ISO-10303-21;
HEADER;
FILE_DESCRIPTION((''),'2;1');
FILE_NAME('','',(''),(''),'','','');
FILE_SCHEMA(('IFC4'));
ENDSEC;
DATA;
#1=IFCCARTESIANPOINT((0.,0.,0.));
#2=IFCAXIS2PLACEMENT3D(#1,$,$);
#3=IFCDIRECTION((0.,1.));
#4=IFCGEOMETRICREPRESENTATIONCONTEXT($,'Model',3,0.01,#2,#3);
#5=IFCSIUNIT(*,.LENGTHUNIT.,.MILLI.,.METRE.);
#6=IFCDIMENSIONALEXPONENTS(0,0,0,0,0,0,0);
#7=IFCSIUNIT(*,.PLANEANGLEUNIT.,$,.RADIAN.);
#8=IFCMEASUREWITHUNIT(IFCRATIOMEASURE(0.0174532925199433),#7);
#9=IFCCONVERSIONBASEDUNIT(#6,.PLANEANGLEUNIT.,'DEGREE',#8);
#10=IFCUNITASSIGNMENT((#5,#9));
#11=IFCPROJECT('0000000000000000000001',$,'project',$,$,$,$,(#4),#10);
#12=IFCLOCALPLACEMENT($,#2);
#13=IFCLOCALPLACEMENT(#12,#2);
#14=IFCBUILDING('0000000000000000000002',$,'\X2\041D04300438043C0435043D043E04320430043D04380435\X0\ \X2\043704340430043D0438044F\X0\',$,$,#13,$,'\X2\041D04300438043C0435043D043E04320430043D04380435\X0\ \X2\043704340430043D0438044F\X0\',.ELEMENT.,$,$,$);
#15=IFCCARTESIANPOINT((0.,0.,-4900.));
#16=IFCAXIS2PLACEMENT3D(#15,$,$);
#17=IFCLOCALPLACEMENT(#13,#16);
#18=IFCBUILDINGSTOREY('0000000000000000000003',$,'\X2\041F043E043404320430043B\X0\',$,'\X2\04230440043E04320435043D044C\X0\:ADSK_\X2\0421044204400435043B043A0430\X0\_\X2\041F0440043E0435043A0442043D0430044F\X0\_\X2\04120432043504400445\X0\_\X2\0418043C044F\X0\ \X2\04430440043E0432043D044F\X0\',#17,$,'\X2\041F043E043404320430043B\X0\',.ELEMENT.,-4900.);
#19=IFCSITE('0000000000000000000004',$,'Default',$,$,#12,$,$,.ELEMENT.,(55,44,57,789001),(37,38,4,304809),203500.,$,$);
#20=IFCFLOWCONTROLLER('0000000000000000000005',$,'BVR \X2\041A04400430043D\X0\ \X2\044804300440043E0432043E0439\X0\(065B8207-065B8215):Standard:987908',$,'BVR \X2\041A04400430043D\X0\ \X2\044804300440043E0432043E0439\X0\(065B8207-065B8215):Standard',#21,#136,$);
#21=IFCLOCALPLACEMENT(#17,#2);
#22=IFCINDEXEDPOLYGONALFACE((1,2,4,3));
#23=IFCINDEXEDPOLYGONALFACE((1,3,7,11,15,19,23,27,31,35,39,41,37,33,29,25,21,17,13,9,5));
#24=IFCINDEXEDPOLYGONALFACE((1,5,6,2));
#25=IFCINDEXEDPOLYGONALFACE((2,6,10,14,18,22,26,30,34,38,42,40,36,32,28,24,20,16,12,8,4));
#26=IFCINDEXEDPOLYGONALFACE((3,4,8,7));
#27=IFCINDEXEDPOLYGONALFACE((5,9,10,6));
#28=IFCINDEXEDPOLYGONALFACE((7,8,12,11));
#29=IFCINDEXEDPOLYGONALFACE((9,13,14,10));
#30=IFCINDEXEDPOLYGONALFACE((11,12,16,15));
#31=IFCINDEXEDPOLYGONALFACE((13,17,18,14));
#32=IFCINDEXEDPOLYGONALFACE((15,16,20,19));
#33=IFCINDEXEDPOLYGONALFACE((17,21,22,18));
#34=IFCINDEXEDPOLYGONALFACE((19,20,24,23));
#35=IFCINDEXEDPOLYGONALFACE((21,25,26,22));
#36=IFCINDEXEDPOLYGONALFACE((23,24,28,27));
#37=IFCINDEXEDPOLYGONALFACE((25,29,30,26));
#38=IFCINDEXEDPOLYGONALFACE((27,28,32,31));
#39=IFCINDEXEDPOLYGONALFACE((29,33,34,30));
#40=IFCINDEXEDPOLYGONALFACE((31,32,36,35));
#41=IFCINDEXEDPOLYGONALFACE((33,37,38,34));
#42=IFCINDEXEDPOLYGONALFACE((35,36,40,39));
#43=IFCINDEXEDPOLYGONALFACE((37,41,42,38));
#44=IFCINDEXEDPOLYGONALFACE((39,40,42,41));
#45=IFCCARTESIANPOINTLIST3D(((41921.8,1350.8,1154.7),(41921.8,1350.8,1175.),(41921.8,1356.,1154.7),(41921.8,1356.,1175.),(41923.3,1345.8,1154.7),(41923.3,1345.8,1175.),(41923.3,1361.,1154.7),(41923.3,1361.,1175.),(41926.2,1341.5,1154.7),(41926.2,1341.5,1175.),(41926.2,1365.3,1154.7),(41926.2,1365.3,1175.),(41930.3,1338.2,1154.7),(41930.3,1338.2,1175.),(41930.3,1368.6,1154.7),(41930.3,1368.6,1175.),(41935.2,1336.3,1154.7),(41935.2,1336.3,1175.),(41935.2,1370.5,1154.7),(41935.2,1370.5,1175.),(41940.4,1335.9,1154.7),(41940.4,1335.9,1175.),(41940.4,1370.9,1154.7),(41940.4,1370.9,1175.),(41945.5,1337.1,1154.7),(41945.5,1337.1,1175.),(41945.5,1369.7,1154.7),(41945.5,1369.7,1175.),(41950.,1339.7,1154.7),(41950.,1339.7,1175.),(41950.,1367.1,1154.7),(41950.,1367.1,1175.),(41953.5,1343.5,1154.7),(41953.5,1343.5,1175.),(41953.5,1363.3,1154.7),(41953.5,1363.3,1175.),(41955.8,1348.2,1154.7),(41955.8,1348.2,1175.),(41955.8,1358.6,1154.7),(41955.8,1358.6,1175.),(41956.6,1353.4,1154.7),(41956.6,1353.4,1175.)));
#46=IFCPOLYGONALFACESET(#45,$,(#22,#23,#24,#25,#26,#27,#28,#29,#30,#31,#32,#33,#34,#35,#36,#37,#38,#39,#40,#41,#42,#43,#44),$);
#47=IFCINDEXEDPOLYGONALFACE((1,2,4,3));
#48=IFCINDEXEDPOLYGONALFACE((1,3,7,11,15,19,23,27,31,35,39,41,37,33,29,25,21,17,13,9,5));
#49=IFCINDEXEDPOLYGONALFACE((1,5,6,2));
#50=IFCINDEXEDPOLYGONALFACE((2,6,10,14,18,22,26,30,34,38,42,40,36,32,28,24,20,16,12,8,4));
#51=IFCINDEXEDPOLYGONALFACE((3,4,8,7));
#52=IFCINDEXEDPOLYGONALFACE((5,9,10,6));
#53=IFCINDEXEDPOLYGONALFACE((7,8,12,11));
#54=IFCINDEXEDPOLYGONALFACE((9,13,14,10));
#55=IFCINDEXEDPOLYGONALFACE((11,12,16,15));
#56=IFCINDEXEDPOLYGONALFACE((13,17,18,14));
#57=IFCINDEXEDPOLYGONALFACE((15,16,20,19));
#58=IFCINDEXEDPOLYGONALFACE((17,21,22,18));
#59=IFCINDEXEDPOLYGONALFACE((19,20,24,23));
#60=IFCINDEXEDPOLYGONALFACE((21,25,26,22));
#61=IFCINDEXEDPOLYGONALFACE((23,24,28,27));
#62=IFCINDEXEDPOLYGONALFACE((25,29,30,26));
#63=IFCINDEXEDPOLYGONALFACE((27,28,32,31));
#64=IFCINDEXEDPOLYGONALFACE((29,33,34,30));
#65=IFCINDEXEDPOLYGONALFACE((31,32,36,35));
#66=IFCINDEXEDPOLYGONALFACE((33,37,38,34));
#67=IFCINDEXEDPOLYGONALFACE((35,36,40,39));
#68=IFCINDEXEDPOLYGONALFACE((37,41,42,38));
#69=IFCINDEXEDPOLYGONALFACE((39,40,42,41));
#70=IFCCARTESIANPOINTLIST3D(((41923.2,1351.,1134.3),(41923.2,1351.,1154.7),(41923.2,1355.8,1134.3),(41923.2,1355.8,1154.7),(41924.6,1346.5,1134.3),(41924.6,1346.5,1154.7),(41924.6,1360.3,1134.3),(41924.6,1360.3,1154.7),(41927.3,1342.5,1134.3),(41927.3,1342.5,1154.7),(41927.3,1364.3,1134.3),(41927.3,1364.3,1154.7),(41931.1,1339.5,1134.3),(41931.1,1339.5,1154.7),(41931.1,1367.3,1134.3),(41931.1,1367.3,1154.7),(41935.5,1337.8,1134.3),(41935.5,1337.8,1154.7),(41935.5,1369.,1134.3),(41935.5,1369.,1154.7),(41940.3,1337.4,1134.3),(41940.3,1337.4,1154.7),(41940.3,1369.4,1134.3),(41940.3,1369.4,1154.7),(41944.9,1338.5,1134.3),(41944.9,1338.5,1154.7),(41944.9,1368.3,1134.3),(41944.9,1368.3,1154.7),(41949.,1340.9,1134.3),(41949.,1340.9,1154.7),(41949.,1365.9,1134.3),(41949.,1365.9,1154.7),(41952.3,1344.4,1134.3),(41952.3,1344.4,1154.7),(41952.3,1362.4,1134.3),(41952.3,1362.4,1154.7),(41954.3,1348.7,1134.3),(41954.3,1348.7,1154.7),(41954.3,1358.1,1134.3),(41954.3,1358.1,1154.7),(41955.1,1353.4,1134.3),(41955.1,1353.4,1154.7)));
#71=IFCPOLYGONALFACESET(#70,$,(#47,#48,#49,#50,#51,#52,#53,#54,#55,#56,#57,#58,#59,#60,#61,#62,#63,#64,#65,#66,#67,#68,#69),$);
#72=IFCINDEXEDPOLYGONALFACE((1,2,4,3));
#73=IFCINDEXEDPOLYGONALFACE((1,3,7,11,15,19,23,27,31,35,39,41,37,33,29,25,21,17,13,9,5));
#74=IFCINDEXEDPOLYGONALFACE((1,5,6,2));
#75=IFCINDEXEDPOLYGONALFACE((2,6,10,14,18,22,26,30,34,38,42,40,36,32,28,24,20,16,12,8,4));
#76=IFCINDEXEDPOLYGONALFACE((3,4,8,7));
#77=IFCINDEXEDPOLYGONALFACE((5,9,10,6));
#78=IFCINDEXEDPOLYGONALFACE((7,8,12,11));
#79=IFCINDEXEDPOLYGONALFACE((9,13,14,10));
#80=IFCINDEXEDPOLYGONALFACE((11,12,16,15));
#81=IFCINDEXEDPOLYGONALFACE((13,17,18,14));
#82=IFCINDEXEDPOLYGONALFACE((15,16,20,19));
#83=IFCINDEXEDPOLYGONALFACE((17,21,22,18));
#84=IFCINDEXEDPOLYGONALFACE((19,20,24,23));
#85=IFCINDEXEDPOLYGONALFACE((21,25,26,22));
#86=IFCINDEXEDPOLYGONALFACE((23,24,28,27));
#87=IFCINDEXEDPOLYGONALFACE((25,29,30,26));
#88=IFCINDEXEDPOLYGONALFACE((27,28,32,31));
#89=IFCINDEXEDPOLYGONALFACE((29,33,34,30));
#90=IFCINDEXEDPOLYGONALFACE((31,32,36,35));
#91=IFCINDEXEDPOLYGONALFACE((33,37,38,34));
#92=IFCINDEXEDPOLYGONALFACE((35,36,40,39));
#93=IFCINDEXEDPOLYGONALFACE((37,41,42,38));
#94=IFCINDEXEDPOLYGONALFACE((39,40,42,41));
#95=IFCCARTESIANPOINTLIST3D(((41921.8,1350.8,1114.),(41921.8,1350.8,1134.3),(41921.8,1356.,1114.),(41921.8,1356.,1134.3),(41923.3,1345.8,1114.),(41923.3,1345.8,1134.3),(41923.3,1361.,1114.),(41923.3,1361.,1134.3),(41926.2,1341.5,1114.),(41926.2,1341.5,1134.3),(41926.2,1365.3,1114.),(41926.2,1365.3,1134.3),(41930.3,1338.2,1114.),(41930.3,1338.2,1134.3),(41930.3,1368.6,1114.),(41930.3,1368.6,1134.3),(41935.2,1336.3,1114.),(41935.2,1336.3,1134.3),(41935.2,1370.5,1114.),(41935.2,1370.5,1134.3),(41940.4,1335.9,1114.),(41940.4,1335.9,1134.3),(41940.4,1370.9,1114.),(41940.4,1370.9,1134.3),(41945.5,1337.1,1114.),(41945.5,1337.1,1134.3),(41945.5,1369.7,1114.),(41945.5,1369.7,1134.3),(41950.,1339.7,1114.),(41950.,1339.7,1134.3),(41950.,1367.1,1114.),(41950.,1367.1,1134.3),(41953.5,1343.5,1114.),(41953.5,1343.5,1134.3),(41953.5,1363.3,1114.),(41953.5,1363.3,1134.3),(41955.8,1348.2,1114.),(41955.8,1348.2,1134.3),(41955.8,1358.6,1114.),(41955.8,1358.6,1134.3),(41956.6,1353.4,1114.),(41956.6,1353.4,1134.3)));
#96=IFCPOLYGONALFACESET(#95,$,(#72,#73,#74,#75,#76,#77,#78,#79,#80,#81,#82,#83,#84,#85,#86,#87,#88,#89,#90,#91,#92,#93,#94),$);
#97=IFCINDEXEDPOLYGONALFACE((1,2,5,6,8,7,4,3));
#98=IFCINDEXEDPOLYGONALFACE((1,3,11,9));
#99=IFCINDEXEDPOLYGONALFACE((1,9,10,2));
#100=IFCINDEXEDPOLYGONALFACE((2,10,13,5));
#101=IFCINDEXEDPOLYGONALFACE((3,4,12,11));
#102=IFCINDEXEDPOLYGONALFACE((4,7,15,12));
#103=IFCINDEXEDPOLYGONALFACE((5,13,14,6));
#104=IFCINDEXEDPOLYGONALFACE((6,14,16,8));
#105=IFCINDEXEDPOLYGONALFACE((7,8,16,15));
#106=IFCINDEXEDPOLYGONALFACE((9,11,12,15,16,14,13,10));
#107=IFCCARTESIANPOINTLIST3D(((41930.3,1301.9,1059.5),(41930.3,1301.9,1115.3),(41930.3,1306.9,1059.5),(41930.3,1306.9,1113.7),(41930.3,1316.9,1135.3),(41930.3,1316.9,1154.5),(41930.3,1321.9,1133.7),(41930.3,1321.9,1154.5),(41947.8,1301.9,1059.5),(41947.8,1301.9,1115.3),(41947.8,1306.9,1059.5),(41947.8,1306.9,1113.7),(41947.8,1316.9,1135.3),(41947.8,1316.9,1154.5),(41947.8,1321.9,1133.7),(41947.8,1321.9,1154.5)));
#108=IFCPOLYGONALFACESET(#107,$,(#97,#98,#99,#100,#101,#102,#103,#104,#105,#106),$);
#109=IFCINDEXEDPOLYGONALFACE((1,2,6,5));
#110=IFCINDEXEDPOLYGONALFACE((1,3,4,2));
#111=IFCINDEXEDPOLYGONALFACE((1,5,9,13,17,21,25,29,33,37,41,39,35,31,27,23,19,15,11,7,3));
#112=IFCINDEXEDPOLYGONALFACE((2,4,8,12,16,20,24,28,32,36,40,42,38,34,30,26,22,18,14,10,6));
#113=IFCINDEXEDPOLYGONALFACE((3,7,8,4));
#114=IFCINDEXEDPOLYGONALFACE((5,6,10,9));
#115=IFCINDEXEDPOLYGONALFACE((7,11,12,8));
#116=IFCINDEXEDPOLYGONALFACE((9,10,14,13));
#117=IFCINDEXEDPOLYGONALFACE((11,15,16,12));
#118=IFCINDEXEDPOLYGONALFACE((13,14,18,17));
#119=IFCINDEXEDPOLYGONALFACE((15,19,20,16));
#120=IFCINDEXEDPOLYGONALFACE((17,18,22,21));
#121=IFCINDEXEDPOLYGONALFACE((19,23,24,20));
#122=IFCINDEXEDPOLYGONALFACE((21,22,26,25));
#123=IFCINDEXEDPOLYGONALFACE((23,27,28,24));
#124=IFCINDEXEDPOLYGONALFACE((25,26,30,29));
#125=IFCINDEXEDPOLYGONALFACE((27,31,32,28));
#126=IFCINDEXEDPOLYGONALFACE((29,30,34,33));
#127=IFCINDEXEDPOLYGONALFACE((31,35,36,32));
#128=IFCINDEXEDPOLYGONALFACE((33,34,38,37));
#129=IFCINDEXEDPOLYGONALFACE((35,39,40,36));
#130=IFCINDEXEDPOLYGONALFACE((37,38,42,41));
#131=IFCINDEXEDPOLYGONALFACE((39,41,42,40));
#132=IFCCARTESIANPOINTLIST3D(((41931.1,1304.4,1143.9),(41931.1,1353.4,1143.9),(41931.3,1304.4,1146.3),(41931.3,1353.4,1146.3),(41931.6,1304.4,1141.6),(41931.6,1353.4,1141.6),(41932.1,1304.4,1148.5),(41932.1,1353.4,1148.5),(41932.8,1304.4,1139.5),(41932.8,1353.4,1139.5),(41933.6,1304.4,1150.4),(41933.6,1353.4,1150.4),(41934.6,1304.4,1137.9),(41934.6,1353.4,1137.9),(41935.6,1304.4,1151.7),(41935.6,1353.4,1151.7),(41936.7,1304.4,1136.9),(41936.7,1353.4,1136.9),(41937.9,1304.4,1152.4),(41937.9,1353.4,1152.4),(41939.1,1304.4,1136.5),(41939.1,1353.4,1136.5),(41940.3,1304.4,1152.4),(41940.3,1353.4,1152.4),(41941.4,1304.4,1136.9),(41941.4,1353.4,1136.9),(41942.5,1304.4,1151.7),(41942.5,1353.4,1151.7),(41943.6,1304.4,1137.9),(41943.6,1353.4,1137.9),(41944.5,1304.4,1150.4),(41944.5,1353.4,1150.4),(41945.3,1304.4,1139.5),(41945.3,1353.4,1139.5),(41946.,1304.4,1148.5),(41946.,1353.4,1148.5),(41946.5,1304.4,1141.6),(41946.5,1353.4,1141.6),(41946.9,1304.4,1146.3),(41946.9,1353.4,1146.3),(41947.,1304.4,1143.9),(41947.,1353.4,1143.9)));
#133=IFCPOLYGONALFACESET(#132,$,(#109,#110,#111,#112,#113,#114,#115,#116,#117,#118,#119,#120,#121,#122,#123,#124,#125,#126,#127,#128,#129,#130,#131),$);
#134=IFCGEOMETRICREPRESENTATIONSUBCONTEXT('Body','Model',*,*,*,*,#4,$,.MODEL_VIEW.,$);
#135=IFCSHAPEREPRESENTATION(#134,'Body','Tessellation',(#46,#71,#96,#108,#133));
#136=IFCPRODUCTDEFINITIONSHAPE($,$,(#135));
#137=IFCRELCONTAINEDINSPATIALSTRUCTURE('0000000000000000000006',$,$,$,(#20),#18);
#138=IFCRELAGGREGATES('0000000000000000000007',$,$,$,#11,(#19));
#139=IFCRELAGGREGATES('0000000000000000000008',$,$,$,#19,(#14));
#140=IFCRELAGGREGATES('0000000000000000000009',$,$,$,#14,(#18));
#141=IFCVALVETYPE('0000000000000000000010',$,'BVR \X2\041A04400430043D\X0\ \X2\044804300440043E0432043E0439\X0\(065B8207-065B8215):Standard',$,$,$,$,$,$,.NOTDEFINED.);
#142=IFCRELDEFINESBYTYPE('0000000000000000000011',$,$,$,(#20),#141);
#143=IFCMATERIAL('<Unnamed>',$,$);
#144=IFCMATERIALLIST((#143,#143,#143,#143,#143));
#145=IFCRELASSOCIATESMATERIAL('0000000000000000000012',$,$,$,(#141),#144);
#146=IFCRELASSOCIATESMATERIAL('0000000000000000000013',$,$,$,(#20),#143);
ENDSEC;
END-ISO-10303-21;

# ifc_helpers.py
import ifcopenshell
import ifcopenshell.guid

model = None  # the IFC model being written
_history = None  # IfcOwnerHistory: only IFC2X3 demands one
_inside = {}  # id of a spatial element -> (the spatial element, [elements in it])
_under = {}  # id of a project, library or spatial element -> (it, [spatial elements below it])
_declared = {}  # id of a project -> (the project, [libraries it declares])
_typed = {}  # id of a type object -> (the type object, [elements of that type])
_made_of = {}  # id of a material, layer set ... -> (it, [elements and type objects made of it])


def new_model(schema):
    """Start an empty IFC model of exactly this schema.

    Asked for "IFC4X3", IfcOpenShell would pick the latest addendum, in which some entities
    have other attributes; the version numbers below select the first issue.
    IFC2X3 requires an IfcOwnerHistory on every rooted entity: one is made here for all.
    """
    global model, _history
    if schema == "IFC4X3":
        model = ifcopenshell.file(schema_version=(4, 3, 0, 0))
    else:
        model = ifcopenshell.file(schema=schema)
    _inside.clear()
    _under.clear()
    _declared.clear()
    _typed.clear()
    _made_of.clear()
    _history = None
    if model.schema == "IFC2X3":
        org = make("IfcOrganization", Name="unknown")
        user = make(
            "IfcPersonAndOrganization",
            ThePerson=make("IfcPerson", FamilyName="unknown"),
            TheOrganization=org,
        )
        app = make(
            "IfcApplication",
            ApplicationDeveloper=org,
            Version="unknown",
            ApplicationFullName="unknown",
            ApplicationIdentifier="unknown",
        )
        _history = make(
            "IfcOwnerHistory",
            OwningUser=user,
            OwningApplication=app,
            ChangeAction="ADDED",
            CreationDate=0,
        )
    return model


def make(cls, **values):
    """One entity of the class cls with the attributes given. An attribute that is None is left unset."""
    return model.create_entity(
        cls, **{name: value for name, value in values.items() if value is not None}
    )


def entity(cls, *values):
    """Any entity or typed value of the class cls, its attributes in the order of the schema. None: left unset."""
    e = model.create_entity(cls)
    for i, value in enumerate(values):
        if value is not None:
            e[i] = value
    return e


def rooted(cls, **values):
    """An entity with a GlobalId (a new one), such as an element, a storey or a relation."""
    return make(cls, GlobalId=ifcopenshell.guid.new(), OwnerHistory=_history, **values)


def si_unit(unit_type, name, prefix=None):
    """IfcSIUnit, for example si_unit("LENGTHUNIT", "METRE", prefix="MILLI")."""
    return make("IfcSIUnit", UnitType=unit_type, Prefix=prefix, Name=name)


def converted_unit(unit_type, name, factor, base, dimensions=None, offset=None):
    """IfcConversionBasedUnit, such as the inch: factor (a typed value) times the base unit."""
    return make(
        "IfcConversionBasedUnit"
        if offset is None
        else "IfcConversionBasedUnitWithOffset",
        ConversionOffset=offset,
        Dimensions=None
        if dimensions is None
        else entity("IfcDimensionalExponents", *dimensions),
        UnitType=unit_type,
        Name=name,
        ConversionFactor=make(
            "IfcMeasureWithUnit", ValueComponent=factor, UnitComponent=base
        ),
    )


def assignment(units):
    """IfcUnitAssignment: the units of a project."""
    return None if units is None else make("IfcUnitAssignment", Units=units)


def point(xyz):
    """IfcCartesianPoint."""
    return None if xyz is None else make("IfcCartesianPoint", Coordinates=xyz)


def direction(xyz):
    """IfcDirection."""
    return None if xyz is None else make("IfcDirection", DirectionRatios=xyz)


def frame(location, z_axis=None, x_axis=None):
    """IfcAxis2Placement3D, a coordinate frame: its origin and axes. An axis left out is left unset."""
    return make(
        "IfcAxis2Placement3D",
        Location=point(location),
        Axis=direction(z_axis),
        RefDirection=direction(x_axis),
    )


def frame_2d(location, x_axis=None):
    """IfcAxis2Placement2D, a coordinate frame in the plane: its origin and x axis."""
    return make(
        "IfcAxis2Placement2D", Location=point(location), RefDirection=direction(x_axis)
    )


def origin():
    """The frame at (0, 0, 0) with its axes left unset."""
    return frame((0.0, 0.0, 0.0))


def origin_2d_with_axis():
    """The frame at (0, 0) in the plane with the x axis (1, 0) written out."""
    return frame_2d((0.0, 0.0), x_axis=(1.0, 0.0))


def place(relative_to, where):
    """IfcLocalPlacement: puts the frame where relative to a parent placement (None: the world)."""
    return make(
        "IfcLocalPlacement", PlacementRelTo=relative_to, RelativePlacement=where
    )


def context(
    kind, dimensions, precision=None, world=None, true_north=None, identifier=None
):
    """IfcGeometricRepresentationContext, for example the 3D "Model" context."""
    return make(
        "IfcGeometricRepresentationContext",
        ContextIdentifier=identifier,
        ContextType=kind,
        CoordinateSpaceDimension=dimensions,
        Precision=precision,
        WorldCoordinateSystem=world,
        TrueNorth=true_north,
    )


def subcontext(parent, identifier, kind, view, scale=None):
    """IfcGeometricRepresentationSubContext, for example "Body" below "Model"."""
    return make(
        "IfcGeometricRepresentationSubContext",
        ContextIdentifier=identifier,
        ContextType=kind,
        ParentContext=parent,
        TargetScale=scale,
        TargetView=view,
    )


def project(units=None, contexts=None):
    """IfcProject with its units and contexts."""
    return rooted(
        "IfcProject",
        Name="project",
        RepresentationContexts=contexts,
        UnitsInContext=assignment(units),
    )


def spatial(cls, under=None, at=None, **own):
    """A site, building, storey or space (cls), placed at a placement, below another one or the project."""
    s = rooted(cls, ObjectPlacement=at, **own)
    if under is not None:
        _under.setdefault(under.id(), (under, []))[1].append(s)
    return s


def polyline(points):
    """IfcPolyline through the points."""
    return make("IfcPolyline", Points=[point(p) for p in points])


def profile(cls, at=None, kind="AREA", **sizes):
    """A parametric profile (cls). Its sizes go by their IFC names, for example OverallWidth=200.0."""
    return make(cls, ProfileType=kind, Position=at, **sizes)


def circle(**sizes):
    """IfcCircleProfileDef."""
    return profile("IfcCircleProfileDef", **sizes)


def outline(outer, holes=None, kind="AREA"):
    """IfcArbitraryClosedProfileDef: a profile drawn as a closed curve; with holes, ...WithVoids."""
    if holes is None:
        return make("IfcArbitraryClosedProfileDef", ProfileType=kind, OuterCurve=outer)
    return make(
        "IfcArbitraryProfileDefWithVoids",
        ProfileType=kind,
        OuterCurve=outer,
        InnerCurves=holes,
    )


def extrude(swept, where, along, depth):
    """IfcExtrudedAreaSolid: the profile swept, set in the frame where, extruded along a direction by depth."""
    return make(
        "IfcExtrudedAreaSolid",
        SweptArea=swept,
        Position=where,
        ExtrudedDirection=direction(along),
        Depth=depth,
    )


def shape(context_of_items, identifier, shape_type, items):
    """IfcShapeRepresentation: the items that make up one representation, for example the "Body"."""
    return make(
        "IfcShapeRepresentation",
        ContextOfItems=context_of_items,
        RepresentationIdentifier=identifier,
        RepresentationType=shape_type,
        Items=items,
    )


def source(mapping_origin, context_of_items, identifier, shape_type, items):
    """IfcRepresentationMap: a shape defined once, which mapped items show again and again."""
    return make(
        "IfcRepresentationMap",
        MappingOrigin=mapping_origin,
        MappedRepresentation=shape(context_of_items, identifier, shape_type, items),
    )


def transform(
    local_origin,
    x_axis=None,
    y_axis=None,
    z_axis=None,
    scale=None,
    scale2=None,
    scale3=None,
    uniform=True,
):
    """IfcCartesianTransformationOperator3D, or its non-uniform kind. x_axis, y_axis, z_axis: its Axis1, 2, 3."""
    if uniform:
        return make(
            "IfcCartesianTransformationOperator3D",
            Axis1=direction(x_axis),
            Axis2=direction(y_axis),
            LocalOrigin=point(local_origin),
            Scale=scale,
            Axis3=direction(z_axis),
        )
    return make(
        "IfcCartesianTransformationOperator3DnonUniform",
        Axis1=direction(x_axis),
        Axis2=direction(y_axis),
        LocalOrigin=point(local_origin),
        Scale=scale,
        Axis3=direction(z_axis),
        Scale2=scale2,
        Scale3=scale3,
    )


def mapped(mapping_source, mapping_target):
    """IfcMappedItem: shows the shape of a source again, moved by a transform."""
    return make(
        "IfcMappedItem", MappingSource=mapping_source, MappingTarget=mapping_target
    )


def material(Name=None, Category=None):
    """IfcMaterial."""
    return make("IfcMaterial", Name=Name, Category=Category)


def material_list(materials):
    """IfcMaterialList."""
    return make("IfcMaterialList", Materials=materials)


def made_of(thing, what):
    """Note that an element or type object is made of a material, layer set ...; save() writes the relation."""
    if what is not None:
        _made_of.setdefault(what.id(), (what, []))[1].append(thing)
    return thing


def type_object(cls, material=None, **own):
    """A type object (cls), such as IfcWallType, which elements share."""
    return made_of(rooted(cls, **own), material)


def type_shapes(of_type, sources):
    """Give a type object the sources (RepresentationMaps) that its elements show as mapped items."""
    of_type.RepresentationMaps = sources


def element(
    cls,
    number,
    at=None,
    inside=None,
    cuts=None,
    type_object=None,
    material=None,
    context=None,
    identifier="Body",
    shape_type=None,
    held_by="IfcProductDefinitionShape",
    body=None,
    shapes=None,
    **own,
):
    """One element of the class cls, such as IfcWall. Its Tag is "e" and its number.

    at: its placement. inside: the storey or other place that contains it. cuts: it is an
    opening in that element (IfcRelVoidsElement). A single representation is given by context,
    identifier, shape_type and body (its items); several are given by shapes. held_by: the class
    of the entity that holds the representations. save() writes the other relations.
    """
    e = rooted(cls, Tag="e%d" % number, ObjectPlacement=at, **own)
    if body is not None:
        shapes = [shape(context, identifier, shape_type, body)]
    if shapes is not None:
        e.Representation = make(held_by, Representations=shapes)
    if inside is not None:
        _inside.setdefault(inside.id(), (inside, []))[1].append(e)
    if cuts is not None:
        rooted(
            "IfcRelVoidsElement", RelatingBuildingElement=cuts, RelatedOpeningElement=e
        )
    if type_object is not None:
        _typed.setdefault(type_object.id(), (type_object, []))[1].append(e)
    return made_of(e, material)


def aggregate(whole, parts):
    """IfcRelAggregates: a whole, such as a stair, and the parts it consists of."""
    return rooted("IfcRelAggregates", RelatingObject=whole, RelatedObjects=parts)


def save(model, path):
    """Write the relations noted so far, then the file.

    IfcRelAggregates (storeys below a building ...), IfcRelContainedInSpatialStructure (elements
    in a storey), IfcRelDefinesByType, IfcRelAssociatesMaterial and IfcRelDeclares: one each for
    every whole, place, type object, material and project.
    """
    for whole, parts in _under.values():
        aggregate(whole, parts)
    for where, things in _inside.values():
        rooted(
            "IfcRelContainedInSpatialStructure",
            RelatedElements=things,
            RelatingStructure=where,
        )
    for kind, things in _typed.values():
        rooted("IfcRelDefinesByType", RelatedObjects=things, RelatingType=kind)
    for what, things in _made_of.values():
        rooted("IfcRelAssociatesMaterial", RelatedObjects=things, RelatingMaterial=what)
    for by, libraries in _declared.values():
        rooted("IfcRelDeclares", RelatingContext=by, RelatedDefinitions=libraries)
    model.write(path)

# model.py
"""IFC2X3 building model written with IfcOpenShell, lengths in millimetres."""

from ifc_helpers import new_model, entity, si_unit, converted_unit, direction, frame, origin, origin_2d_with_axis, place, context, subcontext, project, spatial, polyline, circle, outline, extrude, source, transform, mapped, material, material_list, type_object, type_shapes, element, save


model = new_model("IFC2X3")

# Units and contexts
model_context = context("Model", 3, precision=0.01, world=origin(), true_north=direction((0.0, 1.0)))
body_context = subcontext(model_context, "Body", "Model", "MODEL_VIEW")
ifc_project = project(units=[si_unit("LENGTHUNIT", "METRE", prefix="MILLI"), converted_unit("PLANEANGLEUNIT", "DEGREE", entity("IfcRatioMeasure", 0.0174532925199433), si_unit("PLANEANGLEUNIT", "RADIAN"), dimensions=[0, 0, 0, 0, 0, 0, 0])], contexts=[model_context])

# Site, building, storey
site_placement = place(None, origin())
site = spatial("IfcSite", under=ifc_project, at=site_placement, Name="Default", CompositionType="ELEMENT", RefLatitude=(55, 44, 57, 789001), RefLongitude=(37, 38, 4, 304809), RefElevation=203500.0)
building_placement = place(site_placement, origin())
building = spatial("IfcBuilding", under=site, at=building_placement, Name="Наименование здания", LongName="Наименование здания", CompositionType="ELEMENT")
storey_placement = place(building_placement, frame((0.0, 0.0, -4900.0)))
storey = spatial("IfcBuildingStorey", under=building, at=storey_placement, Name="Подвал", ObjectType="Уровень:ADSK_Стрелка_Проектная_Вверх_Имя уровня", LongName="Подвал", CompositionType="ELEMENT", Elevation=-4900.0)

# Flow controller
ifc_material = material(Name="<Unnamed>")
ifc_material_list = material_list([ifc_material, ifc_material, ifc_material, ifc_material, ifc_material])
valve_type = type_object("IfcValveType", Name="BVR Кран шаровой(065B8207-065B8215):Standard", PredefinedType="NOTDEFINED", material=ifc_material_list)
shared_shape = source(origin(), body_context, "Body", "SweptSolid", [
    extrude(circle(Radius=17.5, at=origin_2d_with_axis()), frame((-30.5, 0.0, 0.0), z_axis=(1.0, 0.0, 0.0), x_axis=(0.0, 1.0, 0.0)), (0.0, 0.0, 1.0), 20.3),
    extrude(circle(Radius=16.0, at=origin_2d_with_axis()), frame((-10.2, 0.0, 0.0), z_axis=(1.0, 0.0, 0.0), x_axis=(0.0, 1.0, 0.0)), (0.0, 0.0, 1.0), 20.3),
    extrude(circle(Radius=17.5, at=origin_2d_with_axis()), frame((10.2, 0.0, 0.0), z_axis=(1.0, 0.0, 0.0), x_axis=(0.0, 1.0, 0.0)), (0.0, 0.0, 1.0), 20.3),
    extrude(outline(polyline([(-38.8, -5.0), (-38.8, -10.0), (-17.9, -10.0), (2.1, 5.0), (56.2, 5.0), (56.2, 10.0), (0.4, 10.0), (-19.6, -5.0), (-38.8, -5.0)])), frame((28.8, -8.8, 41.5), z_axis=(0.0, -1.0, 0.0), x_axis=(1.0, 0.0, 0.0)), (0.0, 0.0, -1.0), 17.5),
    extrude(circle(Radius=8.0, at=origin_2d_with_axis()), origin(), (0.0, 0.0, 1.0), 49.0),
])
type_shapes(valve_type, [shared_shape])
for number, where, z_axis, x_axis, name in (
    (1, (41939.1, 1353.4, 1144.5), (0.0, -1.0, 0.0), (0.0, 0.0, -1.0), "BVR Кран шаровой(065B8207-065B8215):Standard:987908"),
):
    element("IfcFlowController", number, at=place(storey_placement, frame(where, z_axis=z_axis, x_axis=x_axis)), inside=storey, type_object=valve_type, material=ifc_material, Name=name, ObjectType="BVR Кран шаровой(065B8207-065B8215):Standard", context=body_context, shape_type="MappedRepresentation", body=[
        mapped(shared_shape, transform((0.0, 0.0, 0.0), scale=1.0)),
    ])

save(model, "model.ifc")
